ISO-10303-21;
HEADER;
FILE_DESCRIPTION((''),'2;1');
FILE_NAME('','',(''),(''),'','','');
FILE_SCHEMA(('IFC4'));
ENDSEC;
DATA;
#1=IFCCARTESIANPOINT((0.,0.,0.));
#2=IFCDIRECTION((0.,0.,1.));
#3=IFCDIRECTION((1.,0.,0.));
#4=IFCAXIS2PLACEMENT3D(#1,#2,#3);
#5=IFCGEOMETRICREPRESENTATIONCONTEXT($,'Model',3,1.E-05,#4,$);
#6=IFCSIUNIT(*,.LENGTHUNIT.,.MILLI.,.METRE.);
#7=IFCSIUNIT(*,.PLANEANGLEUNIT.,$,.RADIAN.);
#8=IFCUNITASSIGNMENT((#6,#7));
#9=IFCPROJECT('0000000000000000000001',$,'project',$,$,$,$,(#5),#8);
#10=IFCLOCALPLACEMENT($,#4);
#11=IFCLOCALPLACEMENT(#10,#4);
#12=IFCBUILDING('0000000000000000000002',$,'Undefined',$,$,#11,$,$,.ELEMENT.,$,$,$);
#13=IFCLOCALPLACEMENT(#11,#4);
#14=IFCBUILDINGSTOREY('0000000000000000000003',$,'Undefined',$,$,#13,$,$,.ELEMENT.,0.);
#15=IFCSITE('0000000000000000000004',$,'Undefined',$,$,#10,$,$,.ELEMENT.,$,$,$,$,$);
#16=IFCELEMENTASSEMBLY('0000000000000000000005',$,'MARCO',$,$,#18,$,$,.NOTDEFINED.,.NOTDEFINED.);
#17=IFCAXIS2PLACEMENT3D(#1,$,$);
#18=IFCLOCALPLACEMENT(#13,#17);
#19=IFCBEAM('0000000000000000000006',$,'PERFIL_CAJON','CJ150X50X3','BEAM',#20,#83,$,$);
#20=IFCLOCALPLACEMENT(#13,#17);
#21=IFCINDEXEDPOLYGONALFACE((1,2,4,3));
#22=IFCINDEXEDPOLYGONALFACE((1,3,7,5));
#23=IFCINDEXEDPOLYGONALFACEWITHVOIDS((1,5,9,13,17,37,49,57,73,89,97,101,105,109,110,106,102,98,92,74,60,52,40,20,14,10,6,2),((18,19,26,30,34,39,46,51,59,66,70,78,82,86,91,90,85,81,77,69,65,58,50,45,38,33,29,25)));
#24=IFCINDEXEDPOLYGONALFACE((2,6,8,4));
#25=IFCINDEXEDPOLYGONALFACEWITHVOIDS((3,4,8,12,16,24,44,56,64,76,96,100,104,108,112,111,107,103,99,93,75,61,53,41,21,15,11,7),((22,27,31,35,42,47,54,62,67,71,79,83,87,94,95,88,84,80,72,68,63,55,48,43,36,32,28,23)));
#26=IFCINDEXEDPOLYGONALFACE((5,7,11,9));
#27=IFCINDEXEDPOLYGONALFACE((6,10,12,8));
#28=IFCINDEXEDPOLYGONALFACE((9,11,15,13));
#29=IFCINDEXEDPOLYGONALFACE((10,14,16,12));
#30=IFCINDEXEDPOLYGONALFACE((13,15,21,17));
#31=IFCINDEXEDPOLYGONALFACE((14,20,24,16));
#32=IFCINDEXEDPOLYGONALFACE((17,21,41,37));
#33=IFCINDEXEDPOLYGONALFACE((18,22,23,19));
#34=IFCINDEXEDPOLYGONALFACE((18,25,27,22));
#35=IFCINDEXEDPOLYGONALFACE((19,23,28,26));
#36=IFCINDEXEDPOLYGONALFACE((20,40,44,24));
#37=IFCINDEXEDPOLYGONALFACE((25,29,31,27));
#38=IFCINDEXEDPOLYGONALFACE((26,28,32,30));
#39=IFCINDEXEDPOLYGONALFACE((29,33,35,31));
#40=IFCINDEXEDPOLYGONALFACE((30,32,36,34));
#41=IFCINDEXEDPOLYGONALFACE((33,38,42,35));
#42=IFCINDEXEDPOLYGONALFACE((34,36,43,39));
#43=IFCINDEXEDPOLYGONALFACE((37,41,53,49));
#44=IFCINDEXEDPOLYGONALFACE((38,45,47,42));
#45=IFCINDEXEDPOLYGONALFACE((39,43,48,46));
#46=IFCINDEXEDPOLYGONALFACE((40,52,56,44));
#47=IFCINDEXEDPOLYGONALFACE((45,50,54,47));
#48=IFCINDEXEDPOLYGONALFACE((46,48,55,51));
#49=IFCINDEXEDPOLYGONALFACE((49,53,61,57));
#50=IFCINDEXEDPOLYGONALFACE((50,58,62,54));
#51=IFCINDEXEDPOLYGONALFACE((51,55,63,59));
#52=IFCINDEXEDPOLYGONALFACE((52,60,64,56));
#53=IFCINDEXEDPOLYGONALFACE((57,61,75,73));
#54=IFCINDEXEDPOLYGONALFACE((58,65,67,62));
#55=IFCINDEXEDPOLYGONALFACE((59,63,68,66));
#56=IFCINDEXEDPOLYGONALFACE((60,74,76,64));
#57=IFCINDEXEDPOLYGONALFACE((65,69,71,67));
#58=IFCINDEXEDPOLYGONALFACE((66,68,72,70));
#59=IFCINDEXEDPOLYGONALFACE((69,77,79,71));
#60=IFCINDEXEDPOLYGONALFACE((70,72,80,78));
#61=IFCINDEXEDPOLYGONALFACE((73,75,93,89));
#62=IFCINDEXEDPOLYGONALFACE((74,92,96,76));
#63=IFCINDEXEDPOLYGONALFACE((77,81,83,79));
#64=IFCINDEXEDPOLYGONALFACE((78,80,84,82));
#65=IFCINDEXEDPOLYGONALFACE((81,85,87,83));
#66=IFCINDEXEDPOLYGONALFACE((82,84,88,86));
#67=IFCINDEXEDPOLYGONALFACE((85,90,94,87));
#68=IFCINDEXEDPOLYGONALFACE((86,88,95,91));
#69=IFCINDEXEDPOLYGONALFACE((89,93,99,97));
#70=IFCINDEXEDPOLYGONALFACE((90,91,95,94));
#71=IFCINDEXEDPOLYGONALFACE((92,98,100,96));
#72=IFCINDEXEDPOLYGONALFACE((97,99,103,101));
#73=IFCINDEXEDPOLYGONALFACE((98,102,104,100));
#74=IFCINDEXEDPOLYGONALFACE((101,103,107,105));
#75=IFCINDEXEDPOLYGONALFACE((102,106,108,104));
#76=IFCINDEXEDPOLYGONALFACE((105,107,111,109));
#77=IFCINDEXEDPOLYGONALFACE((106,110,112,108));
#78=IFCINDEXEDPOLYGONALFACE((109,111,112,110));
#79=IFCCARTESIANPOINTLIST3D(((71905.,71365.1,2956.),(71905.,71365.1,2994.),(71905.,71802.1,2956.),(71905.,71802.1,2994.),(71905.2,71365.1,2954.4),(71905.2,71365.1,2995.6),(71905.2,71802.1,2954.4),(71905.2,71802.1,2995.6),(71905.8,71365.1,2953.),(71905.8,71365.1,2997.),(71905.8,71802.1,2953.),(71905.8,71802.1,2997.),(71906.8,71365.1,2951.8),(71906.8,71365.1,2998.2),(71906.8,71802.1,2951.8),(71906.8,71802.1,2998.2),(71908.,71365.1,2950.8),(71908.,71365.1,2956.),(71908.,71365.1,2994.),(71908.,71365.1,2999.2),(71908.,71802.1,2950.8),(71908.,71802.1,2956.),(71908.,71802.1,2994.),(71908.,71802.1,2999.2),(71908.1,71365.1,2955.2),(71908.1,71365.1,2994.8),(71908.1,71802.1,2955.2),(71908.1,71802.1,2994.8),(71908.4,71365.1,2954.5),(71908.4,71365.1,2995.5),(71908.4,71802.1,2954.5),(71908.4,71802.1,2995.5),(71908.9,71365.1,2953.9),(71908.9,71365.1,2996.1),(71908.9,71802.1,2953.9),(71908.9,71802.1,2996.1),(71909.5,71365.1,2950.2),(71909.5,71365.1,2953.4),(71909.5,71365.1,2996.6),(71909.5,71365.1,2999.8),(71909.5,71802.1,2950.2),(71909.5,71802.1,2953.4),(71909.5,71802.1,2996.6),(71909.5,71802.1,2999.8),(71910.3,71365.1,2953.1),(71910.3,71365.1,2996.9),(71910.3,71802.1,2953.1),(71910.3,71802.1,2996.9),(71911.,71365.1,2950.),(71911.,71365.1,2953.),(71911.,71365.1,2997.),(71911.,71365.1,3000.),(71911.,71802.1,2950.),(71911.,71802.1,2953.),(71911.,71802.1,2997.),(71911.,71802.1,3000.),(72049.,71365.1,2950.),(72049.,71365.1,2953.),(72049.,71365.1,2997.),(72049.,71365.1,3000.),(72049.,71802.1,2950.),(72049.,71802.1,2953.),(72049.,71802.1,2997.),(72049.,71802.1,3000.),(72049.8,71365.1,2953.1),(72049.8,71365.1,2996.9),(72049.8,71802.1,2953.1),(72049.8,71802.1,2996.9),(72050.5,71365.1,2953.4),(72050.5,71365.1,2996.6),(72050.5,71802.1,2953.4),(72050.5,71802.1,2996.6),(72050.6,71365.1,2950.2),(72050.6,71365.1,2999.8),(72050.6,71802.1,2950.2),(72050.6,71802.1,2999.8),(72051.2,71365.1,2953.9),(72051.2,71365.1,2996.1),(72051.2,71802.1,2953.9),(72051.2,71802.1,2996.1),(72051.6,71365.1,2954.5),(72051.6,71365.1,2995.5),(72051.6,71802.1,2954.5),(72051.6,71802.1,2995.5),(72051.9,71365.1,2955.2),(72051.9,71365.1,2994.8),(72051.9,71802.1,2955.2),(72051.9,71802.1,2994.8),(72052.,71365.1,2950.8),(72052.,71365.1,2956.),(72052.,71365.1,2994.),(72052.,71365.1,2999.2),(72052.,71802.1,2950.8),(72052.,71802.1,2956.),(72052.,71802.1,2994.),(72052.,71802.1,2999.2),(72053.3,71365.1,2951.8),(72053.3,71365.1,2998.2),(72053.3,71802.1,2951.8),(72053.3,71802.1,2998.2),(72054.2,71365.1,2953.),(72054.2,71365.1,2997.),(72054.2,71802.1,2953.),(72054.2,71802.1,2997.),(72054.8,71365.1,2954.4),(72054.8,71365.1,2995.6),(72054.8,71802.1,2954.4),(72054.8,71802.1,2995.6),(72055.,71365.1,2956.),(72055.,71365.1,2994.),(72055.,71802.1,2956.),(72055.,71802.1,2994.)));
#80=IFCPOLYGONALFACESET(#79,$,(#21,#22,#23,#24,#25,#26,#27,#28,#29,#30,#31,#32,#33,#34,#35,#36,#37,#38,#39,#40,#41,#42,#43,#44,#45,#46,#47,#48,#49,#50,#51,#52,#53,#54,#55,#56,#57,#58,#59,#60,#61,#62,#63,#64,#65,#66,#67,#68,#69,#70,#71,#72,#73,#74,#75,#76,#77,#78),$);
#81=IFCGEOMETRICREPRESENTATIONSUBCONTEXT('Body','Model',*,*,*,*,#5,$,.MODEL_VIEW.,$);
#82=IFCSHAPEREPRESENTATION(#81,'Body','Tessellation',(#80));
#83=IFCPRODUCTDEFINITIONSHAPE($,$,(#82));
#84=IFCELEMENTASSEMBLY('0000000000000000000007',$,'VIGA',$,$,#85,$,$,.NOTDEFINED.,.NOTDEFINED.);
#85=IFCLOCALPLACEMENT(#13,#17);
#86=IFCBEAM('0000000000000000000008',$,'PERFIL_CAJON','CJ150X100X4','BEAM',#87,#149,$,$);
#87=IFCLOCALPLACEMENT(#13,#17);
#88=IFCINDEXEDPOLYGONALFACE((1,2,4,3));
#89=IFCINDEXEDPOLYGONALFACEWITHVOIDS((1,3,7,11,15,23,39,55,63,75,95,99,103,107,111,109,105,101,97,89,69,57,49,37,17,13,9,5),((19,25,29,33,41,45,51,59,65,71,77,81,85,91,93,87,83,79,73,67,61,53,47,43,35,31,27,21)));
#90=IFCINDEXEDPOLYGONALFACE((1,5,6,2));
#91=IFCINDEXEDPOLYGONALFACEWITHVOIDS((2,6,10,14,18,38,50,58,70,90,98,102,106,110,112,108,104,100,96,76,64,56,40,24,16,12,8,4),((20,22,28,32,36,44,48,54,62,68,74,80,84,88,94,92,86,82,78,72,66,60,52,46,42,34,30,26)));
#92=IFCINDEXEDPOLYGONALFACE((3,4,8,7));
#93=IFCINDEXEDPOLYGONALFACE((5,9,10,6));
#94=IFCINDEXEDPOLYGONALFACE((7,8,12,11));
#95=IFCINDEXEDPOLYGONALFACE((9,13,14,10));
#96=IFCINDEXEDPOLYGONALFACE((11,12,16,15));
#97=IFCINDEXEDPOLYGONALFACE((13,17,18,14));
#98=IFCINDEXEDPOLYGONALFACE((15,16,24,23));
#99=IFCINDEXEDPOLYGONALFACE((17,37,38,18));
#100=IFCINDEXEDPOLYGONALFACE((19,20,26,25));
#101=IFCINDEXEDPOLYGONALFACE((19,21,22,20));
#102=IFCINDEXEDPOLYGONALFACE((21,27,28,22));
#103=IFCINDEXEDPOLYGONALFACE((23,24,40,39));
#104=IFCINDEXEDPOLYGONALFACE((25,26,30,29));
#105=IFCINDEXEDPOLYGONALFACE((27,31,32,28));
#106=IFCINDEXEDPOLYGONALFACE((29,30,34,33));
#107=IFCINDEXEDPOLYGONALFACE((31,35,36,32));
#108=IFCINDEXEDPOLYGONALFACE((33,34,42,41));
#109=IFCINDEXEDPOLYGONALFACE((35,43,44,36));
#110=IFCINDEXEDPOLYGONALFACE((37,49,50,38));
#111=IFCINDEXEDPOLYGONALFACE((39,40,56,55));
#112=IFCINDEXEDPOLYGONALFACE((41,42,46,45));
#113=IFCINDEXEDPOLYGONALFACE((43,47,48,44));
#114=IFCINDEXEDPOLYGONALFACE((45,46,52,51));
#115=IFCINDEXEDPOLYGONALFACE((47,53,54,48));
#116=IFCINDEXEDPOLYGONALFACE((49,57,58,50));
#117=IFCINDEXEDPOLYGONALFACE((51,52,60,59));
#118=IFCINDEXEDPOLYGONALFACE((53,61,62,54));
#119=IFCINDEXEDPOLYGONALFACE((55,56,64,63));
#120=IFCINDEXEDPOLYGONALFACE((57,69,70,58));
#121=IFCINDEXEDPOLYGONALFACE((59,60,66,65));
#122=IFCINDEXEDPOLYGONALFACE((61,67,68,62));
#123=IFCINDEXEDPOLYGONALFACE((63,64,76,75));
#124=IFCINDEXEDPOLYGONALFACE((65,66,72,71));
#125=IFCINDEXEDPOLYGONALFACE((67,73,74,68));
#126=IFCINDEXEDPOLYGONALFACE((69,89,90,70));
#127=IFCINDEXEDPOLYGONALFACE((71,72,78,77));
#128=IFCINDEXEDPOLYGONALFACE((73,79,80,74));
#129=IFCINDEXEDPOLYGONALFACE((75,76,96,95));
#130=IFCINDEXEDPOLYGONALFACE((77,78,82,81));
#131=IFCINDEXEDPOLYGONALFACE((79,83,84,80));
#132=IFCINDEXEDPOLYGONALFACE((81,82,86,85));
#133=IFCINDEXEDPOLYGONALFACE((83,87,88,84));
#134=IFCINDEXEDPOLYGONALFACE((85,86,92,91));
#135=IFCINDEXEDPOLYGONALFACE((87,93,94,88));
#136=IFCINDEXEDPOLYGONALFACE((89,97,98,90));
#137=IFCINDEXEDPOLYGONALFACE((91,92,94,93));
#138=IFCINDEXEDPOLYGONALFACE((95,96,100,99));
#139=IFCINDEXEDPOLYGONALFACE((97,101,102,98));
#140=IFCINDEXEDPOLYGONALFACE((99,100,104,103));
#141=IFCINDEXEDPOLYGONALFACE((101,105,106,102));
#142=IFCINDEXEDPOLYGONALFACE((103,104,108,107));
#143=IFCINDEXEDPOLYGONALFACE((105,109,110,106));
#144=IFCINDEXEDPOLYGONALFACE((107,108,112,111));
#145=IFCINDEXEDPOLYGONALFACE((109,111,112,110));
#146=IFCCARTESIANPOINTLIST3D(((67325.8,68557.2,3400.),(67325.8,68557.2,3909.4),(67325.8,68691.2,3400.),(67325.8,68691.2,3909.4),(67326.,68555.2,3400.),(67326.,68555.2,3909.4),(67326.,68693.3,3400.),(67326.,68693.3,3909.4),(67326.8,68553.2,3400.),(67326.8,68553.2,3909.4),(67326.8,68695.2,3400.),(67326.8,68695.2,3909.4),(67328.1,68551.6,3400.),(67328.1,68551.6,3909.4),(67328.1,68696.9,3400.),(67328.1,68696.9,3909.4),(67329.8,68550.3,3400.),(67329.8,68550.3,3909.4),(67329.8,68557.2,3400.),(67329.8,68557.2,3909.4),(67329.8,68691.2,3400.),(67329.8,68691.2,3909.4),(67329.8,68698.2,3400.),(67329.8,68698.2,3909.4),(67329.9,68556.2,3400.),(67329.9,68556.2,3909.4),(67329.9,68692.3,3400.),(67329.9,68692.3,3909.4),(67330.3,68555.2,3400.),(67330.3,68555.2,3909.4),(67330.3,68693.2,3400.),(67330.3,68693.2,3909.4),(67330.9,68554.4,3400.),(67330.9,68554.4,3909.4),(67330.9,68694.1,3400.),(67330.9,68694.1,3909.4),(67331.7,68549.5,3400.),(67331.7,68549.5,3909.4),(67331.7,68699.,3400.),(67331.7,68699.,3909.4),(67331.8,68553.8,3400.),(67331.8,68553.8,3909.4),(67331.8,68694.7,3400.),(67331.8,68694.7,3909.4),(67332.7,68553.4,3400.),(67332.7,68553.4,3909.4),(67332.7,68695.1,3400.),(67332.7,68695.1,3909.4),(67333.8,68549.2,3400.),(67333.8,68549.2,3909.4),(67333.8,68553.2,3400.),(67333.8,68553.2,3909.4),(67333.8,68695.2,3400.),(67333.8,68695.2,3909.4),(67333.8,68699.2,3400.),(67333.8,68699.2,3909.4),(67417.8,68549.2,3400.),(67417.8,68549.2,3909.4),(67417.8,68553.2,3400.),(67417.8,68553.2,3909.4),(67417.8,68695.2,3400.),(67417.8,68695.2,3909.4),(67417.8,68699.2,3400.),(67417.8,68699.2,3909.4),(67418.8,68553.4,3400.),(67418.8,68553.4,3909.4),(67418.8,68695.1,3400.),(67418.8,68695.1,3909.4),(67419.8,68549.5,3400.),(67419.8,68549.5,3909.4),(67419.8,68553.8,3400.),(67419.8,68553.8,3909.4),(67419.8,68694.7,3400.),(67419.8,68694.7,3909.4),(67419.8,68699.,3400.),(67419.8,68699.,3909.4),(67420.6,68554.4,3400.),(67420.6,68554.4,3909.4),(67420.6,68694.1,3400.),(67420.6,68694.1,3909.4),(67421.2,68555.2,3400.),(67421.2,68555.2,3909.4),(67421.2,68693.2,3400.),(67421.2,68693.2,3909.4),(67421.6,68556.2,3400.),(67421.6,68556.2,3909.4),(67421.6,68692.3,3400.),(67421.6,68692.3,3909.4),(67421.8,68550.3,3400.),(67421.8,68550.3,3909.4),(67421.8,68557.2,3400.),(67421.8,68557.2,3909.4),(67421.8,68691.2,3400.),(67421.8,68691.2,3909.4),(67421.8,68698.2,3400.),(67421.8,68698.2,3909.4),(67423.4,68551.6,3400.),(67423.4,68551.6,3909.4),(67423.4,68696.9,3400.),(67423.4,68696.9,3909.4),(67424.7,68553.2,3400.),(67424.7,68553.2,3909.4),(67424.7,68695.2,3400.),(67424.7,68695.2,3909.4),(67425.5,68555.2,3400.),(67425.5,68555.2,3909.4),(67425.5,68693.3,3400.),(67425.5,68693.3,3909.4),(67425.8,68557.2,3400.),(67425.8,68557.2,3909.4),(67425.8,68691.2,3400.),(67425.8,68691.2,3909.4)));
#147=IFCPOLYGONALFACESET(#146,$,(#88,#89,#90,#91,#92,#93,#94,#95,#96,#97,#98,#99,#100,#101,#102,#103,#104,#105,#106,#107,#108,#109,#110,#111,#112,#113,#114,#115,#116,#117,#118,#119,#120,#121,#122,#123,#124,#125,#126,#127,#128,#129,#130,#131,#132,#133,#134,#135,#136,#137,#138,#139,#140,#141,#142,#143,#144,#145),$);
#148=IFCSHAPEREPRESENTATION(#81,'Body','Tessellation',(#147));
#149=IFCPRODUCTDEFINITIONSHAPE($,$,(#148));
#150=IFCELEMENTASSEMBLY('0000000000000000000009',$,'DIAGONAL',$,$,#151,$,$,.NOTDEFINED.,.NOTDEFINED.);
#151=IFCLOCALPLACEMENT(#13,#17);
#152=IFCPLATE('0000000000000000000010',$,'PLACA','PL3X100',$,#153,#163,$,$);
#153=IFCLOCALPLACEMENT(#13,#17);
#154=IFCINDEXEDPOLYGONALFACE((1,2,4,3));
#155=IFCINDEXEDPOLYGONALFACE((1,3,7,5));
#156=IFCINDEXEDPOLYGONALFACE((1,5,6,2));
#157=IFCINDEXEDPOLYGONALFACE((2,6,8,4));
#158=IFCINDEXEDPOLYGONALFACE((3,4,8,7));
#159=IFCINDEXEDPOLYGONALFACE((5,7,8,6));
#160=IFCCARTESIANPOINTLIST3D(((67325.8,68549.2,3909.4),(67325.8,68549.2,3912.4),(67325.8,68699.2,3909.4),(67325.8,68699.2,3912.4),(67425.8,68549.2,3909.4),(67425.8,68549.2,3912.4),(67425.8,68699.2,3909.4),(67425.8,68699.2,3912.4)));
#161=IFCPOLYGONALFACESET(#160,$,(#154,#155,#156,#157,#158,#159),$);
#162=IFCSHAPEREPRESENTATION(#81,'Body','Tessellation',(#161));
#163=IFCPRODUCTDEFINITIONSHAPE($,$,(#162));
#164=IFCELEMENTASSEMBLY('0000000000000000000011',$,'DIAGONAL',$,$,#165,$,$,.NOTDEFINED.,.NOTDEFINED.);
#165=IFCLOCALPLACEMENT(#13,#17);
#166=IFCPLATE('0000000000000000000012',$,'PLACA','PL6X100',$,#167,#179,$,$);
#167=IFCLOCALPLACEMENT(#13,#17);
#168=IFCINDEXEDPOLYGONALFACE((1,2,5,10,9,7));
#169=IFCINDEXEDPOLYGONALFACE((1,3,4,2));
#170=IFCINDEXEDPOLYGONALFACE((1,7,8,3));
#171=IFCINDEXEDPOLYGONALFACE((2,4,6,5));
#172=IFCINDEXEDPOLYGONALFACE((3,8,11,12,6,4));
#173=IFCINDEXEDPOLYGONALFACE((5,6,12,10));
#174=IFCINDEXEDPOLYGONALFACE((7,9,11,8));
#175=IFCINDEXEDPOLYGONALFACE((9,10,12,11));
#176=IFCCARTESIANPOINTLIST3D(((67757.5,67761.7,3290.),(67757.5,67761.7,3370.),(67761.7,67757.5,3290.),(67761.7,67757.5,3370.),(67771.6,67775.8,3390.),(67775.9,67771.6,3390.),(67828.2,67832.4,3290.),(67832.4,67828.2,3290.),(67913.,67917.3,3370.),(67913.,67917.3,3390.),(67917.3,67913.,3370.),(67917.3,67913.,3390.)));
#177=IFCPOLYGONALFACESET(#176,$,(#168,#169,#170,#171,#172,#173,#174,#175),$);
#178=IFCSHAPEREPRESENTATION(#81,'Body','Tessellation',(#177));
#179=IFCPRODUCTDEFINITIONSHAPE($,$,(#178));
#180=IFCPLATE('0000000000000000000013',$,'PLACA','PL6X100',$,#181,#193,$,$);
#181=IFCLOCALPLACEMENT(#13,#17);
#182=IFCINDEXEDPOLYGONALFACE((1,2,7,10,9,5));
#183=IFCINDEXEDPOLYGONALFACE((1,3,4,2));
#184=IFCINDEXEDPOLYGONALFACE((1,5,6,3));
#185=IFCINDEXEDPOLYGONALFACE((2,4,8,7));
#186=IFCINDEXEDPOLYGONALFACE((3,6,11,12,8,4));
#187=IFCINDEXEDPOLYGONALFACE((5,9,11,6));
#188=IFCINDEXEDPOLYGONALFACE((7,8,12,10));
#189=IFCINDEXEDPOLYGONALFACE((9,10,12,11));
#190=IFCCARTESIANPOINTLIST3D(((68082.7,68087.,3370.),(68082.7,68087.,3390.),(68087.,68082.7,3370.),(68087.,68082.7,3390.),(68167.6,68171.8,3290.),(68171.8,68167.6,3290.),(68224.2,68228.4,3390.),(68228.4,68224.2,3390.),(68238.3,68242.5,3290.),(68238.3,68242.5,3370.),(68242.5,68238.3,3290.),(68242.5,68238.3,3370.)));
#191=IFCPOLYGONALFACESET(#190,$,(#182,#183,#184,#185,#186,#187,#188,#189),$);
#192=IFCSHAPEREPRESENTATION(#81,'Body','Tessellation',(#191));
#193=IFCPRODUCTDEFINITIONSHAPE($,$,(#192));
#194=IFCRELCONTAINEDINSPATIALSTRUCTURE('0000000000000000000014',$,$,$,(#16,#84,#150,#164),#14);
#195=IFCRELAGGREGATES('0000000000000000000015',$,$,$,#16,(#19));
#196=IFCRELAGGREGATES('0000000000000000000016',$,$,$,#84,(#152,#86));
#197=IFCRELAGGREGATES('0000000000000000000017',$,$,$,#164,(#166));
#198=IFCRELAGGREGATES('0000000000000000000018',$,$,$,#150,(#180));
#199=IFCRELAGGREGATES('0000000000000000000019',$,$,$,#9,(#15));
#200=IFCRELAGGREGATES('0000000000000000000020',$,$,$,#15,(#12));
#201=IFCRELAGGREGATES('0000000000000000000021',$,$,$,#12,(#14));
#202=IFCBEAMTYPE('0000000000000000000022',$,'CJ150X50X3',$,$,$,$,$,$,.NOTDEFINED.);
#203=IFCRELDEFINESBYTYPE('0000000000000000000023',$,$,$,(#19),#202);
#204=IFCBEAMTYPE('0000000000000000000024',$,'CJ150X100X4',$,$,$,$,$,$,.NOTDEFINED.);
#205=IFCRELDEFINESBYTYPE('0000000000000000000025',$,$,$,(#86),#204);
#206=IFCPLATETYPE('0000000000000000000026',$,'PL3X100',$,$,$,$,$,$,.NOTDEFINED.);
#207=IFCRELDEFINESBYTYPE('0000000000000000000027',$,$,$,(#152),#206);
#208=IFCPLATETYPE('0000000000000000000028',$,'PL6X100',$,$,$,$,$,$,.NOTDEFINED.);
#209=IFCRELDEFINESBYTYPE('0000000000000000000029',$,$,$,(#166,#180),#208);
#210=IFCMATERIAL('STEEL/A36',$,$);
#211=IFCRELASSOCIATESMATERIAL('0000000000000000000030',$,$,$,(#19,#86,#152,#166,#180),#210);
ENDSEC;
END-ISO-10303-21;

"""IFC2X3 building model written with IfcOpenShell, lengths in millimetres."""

from ifc_helpers import new_model, si_unit, frame, origin_with_axes, origin_2d_with_axis, place, context, subcontext, project, spatial, polyline, hollow_rectangle, outline, extrude, material, type_object, element, aggregate, save


model = new_model("IFC2X3")

# Units and contexts
model_context = context("Model", 3, precision=1e-05, world=origin_with_axes())
body_context = subcontext(model_context, "Body", "Model", "MODEL_VIEW")
ifc_project = project(units=[si_unit("LENGTHUNIT", "METRE", prefix="MILLI"), si_unit("PLANEANGLEUNIT", "RADIAN")], contexts=[model_context])

# Site, building, storey
site_placement = place(None, origin_with_axes())
site = spatial("IfcSite", under=ifc_project, at=site_placement, Name="Undefined", CompositionType="ELEMENT")
building_placement = place(site_placement, origin_with_axes())
building = spatial("IfcBuilding", under=site, at=building_placement, Name="Undefined", CompositionType="ELEMENT")
storey_placement = place(building_placement, origin_with_axes())
storey = spatial("IfcBuildingStorey", under=building, at=storey_placement, Name="Undefined", CompositionType="ELEMENT", Elevation=0.0)

# Element assemblies, beams
assembly_1_placement = place(storey_placement, origin_with_axes())
assembly_1 = element("IfcElementAssembly", 1, at=assembly_1_placement, inside=storey, Name="MARCO", AssemblyPlace="NOTDEFINED", PredefinedType="NOTDEFINED")
ifc_material_1 = material(Name="STEEL/A36")
beam_type_1 = type_object("IfcBeamType", Name="CJ150X50X3", PredefinedType="NOTDEFINED")
beam_1_placement = place(assembly_1_placement, frame((71980.0, 71365.1, 2975.0), z_axis=(-1.0, 0.0, 0.0), x_axis=(0.0, 1.0, 0.0)))
beam_1 = element("IfcBeam", 2, at=beam_1_placement, type_object=beam_type_1, material=ifc_material_1, Name="PERFIL_CAJON", Description="CJ150X50X3", ObjectType="BEAM", context=body_context, shape_type="SweptSolid", body=[
    extrude(hollow_rectangle(XDim=50.0, YDim=150.0, WallThickness=3.0, InnerFilletRadius=3.0, OuterFilletRadius=6.0, at=origin_2d_with_axis()), frame((437.0, 0.0, 0.0), z_axis=(-1.0, 0.0, 0.0), x_axis=(0.0, -1.0, 0.0)), (0.0, 0.0, 1.0), 437.0),
])
assembly_2_placement = place(storey_placement, origin_with_axes())
assembly_2 = element("IfcElementAssembly", 3, at=assembly_2_placement, inside=storey, Name="VIGA", AssemblyPlace="NOTDEFINED", PredefinedType="NOTDEFINED")
beam_type_2 = type_object("IfcBeamType", Name="CJ150X100X4", PredefinedType="NOTDEFINED")
beam_2_placement = place(assembly_2_placement, frame((67375.8, 68624.2, 3909.4), z_axis=(0.0, 1.0, 0.0), x_axis=(0.0, 0.0, -1.0)))
beam_2 = element("IfcBeam", 4, at=beam_2_placement, type_object=beam_type_2, material=ifc_material_1, Name="PERFIL_CAJON", Description="CJ150X100X4", ObjectType="BEAM", context=body_context, shape_type="SweptSolid", body=[
    extrude(hollow_rectangle(XDim=100.0, YDim=150.0, WallThickness=4.0, InnerFilletRadius=4.0, OuterFilletRadius=8.0, at=origin_2d_with_axis()), frame((509.4, 0.0, 0.0), z_axis=(-1.0, 0.0, 0.0), x_axis=(0.0, -1.0, 0.0)), (0.0, 0.0, 1.0), 509.4),
])
assembly_3_placement = place(storey_placement, origin_with_axes())
assembly_3 = element("IfcElementAssembly", 5, at=assembly_3_placement, inside=storey, Name="DIAGONAL", AssemblyPlace="NOTDEFINED", PredefinedType="NOTDEFINED")

# Plate
plate_type_1 = type_object("IfcPlateType", Name="PL3X100", PredefinedType="NOTDEFINED")
plate_1_placement = place(assembly_2_placement, frame((67425.8, 68549.2, 3910.9), z_axis=(0.0, 0.0, -1.0), x_axis=(-1.0, 0.0, 0.0)))
plate_1 = element("IfcPlate", 6, at=plate_1_placement, type_object=plate_type_1, material=ifc_material_1, Name="PLACA", Description="PL3X100", context=body_context, shape_type="SweptSolid", body=[
    extrude(outline(polyline([(0.0, 0.0), (100.0, 0.0), (100.0, 150.0), (0.0, 150.0), (0.0, 0.0)])), frame((0.0, 0.0, -1.5), z_axis=(0.0, 0.0, 1.0), x_axis=(1.0, 0.0, 0.0)), (0.0, 0.0, 1.0), 3.0),
])

# Element assembly, plate
assembly_4_placement = place(storey_placement, origin_with_axes())
assembly_4 = element("IfcElementAssembly", 7, at=assembly_4_placement, inside=storey, Name="DIAGONAL", AssemblyPlace="NOTDEFINED", PredefinedType="NOTDEFINED")
plate_type_2 = type_object("IfcPlateType", Name="PL6X100", PredefinedType="NOTDEFINED")
plate_2_placement = place(assembly_4_placement, frame((67915.2, 67915.1, 3290.0), z_axis=(-0.707107, 0.707107, 0.0), x_axis=(-0.707107, -0.707107, 0.0)))
plate_2 = element("IfcPlate", 8, at=plate_2_placement, type_object=plate_type_2, material=ifc_material_1, Name="PLACA", Description="PL6X100", context=body_context, shape_type="SweptSolid", body=[
    extrude(outline(polyline([(0.0, 80.0), (120.0, 0.0), (220.0, 0.0), (220.0, 80.0), (200.0, 100.0), (0.0, 100.0), (0.0, 80.0)])), frame((0.0, 0.0, -3.0), z_axis=(0.0, 0.0, 1.0), x_axis=(1.0, 0.0, 0.0)), (0.0, 0.0, 1.0), 6.0),
])

# Plate
plate_3_placement = place(assembly_3_placement, frame((68084.9, 68084.9, 3290.0), z_axis=(0.707107, -0.707107, 0.0), x_axis=(0.707107, 0.707107, 0.0)))
plate_3 = element("IfcPlate", 9, at=plate_3_placement, type_object=plate_type_2, material=ifc_material_1, Name="PLACA", Description="PL6X100", context=body_context, shape_type="SweptSolid", body=[
    extrude(outline(polyline([(0.0, 80.0), (120.0, 0.0), (220.0, 0.0), (220.0, 80.0), (200.0, 100.0), (0.0, 100.0), (0.0, 80.0)])), frame((0.0, 0.0, -3.0), z_axis=(0.0, 0.0, 1.0), x_axis=(1.0, 0.0, 0.0)), (0.0, 0.0, 1.0), 6.0),
])
aggregate(assembly_1, [beam_1])

aggregate(assembly_2, [plate_1, beam_2])

aggregate(assembly_4, [plate_2])
aggregate(assembly_3, [plate_3])

save(model, "model.ifc")
